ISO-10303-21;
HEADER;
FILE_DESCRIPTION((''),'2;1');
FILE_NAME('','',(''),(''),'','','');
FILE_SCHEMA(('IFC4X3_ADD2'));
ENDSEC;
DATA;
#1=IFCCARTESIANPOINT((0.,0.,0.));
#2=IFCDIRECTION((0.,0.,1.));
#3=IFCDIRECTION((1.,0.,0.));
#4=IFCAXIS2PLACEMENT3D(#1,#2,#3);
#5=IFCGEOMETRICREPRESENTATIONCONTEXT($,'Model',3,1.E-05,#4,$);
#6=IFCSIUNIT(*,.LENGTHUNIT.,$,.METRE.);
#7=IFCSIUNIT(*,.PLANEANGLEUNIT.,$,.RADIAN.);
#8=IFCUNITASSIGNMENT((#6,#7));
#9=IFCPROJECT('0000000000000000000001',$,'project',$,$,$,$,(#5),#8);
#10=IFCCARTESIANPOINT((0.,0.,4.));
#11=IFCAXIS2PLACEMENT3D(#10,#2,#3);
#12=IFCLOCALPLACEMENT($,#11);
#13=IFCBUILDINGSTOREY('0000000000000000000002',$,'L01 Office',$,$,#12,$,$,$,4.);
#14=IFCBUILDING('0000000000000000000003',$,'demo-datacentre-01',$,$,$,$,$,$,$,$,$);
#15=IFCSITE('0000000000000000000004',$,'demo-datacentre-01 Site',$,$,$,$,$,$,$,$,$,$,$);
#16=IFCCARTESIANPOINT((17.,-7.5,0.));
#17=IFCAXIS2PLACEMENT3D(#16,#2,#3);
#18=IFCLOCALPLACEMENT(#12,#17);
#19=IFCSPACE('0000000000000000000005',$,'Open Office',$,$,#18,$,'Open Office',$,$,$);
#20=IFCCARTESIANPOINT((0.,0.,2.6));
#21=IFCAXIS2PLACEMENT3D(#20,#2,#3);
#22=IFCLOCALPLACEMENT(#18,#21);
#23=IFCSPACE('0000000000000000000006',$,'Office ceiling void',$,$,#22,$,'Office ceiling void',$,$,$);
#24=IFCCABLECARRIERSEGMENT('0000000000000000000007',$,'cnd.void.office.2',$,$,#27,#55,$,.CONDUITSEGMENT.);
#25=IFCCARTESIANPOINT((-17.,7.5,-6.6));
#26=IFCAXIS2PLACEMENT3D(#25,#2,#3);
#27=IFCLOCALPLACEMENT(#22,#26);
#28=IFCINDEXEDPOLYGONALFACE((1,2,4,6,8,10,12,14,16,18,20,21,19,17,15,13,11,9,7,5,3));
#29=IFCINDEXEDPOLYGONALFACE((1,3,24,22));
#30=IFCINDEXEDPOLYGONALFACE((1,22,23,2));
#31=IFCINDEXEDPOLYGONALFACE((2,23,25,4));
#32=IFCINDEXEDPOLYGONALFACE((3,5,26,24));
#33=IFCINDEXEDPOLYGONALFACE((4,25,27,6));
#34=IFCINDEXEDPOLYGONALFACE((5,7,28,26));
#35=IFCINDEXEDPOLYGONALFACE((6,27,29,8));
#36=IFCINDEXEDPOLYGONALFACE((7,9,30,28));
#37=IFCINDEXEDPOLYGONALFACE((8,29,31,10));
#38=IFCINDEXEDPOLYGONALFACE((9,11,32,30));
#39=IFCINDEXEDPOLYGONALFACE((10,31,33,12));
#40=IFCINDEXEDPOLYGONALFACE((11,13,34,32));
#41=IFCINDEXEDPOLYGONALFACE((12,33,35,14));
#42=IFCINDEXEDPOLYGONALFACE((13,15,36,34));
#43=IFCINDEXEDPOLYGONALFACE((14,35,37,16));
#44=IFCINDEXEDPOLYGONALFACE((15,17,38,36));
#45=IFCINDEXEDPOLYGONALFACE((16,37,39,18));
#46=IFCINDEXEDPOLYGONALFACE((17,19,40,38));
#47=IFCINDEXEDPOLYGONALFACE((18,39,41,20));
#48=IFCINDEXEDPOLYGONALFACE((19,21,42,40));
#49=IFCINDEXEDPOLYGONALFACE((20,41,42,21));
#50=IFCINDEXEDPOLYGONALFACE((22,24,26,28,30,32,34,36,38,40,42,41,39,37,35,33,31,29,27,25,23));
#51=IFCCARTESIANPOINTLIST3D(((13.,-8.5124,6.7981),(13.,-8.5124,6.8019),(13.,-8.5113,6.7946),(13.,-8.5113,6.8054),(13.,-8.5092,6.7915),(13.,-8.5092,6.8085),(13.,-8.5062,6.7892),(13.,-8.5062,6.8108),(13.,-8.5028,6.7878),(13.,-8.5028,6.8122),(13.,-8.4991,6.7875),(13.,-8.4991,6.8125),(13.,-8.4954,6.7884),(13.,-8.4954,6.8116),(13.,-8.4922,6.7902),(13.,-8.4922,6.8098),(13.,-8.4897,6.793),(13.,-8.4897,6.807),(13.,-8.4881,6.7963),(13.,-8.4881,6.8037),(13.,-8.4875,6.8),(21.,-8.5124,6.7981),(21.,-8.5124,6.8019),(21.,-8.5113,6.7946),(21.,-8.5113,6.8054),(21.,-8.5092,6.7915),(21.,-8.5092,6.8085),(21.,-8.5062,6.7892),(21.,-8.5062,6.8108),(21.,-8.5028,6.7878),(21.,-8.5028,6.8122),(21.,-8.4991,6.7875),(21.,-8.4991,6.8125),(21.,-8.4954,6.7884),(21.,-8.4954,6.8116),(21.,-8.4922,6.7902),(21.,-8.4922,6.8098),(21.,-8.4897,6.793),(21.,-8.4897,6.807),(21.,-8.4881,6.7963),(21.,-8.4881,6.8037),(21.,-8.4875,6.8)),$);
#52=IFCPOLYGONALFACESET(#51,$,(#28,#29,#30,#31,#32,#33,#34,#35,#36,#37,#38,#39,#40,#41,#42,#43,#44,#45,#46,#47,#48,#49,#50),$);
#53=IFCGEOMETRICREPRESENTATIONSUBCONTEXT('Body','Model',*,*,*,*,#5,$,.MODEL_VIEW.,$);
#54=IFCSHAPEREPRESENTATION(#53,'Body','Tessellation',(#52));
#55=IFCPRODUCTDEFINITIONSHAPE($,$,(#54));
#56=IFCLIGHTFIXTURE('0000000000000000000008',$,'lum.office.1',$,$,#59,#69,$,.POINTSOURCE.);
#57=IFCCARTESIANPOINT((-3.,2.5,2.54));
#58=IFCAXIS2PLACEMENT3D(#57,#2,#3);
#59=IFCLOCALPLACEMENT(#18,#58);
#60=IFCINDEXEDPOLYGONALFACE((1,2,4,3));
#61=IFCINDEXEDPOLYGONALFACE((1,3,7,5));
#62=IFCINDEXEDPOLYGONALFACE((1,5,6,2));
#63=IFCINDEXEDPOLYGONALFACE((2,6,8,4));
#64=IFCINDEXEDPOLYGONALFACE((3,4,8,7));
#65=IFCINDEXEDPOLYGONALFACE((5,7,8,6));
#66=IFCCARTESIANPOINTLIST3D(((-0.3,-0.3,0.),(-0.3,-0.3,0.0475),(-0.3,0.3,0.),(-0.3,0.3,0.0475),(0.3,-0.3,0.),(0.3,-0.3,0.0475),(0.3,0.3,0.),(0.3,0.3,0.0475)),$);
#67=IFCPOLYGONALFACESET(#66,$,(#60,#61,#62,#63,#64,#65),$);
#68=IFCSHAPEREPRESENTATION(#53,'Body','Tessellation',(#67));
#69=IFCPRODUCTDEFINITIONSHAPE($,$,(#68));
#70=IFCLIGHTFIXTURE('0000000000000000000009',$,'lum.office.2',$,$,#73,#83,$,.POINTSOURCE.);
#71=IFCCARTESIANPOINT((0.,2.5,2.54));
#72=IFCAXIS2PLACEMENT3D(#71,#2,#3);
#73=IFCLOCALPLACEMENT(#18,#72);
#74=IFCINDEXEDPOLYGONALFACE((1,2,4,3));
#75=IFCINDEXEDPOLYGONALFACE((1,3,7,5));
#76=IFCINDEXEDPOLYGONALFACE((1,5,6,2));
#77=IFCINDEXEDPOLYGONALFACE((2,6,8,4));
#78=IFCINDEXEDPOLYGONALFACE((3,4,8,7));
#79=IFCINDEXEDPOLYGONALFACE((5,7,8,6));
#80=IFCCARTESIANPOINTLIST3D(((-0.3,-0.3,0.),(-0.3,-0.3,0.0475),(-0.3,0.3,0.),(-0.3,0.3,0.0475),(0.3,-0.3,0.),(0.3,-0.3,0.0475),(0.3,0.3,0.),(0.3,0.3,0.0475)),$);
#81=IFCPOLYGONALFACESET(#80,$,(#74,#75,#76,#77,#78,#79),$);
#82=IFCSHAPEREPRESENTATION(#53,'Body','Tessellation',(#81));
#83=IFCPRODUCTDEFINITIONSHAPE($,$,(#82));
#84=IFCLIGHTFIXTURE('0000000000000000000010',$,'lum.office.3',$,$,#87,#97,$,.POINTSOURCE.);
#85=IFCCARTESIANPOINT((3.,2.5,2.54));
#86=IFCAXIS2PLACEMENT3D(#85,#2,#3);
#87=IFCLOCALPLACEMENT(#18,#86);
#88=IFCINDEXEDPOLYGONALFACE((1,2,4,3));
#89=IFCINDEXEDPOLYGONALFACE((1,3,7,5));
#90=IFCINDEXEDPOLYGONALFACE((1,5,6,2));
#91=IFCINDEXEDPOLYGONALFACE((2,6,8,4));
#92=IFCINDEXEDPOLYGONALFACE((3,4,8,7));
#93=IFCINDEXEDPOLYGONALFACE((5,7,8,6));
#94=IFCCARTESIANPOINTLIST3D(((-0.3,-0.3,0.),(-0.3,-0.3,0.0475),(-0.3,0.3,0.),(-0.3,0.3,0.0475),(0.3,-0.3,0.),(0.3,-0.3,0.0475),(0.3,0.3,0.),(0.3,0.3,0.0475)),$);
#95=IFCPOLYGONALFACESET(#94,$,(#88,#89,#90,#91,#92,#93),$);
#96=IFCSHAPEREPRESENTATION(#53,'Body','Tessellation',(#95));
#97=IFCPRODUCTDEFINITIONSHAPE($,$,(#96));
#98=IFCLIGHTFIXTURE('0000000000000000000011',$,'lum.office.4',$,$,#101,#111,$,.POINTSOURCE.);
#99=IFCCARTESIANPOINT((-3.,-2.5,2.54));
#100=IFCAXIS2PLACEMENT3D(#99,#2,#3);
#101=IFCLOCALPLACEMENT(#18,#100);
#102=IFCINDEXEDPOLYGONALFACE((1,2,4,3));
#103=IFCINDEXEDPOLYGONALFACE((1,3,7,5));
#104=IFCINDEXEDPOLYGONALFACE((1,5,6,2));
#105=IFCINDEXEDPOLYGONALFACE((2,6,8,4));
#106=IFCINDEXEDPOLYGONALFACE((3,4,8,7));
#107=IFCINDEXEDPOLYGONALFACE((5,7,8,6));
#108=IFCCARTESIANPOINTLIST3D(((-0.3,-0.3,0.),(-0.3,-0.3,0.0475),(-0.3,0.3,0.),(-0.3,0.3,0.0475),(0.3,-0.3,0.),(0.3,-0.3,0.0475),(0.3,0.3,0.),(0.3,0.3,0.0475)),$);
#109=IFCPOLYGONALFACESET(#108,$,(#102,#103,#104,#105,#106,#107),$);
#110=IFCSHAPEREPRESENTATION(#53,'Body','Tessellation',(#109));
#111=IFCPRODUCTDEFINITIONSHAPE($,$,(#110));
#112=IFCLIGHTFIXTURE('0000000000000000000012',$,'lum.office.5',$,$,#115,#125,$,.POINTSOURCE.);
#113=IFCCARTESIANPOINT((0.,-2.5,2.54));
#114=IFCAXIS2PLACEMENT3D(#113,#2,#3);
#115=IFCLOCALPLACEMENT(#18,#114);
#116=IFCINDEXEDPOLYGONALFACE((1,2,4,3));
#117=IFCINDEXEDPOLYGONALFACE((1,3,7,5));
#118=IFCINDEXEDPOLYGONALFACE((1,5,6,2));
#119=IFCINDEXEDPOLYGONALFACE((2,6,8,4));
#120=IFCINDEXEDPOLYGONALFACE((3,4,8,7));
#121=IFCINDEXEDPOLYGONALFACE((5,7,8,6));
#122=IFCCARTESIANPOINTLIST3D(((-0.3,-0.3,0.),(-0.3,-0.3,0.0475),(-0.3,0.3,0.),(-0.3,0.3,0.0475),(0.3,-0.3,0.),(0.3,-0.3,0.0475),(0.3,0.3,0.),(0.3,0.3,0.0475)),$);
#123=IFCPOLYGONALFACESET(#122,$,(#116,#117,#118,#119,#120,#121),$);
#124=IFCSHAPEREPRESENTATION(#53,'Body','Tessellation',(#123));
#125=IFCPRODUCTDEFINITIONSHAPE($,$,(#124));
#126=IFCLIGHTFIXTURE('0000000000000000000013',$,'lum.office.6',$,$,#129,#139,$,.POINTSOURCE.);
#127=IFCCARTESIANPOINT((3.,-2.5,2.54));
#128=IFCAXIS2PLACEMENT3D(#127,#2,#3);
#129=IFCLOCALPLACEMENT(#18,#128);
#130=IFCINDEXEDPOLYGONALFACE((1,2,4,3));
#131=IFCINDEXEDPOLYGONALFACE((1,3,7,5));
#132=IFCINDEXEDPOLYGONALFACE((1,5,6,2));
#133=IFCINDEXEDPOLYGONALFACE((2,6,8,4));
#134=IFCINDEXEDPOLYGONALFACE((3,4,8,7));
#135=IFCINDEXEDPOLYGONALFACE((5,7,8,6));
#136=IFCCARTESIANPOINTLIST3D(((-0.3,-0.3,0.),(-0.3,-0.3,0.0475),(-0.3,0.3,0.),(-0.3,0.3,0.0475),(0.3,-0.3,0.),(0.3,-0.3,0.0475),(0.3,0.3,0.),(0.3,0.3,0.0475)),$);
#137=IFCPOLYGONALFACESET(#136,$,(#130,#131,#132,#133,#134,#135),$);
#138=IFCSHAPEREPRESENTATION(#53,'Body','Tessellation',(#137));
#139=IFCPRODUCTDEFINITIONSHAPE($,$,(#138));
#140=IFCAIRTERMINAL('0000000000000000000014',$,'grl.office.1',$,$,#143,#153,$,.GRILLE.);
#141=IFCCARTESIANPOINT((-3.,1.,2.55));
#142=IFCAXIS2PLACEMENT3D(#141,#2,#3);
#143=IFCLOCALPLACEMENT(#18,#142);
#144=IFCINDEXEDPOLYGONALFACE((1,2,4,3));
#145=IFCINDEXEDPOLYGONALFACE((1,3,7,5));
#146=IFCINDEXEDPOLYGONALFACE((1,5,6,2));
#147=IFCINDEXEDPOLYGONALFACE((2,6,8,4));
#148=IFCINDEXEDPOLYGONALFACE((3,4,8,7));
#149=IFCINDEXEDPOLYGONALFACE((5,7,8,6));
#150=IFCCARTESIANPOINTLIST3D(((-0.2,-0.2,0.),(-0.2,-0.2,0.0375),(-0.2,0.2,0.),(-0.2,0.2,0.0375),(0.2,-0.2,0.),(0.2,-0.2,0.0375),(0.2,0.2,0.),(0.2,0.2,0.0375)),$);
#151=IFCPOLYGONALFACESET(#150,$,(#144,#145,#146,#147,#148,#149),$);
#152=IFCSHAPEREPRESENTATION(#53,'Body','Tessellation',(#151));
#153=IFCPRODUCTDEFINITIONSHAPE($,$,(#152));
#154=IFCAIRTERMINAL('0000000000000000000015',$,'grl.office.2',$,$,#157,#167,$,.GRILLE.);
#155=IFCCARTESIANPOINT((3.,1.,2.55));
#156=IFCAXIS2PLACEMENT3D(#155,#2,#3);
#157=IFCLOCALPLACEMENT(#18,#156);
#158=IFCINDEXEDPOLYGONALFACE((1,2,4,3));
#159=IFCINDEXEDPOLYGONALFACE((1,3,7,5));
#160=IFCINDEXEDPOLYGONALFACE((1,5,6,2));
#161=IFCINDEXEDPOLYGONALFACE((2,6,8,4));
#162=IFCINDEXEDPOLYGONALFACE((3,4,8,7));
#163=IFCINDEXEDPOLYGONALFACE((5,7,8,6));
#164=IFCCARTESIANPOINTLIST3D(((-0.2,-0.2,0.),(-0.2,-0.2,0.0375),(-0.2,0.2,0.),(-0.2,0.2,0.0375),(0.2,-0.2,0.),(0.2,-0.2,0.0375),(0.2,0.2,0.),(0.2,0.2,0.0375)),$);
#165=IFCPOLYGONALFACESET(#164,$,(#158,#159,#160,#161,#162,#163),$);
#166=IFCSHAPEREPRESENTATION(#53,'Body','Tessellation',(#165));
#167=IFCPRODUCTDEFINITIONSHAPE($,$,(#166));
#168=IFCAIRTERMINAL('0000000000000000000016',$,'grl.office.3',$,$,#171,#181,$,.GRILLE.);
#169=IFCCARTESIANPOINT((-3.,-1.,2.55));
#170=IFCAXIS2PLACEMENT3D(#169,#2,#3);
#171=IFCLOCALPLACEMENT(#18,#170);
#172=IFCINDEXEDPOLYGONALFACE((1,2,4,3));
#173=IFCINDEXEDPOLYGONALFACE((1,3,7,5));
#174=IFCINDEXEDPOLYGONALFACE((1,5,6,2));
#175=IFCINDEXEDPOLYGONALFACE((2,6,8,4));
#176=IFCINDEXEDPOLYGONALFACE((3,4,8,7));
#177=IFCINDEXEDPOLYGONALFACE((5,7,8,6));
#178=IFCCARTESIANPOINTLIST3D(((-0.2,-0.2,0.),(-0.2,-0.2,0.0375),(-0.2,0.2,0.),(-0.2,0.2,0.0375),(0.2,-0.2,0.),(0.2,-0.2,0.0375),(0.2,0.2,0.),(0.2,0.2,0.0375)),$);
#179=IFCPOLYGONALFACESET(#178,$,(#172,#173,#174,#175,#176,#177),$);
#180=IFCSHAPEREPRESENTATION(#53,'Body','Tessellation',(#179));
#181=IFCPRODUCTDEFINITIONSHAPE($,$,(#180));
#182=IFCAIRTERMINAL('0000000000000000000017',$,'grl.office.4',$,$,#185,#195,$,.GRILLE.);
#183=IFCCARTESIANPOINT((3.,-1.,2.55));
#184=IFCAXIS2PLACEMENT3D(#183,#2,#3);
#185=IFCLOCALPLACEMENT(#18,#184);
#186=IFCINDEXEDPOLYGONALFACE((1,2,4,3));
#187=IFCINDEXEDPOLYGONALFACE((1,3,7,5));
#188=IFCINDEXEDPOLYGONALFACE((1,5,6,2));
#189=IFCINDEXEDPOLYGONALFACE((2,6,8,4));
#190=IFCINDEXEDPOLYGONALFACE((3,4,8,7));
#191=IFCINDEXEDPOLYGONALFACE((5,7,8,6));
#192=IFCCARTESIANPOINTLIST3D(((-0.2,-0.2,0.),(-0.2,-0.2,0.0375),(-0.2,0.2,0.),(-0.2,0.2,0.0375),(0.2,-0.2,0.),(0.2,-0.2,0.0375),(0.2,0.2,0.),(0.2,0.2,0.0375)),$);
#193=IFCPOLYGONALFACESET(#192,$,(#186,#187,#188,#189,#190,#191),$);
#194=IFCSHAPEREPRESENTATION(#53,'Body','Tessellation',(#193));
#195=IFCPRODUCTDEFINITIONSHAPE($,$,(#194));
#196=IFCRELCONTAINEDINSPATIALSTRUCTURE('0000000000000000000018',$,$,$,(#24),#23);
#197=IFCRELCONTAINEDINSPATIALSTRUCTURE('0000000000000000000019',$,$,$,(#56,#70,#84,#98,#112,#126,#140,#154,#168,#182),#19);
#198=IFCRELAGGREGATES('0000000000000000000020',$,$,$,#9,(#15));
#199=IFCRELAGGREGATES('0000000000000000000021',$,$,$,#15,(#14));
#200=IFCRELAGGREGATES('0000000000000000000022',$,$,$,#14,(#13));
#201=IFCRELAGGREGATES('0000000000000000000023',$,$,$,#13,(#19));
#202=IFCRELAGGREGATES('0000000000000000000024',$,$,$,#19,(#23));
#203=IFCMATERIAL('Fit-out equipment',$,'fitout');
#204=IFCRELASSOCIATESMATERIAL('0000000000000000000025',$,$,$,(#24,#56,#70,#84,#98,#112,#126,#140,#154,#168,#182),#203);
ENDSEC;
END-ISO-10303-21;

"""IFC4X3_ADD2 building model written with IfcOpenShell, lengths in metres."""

from ifc_helpers import new_model, si_unit, frame, origin_with_axes, place, context, subcontext, project, spatial, rectangle, circle, extrude, material, element, save


model = new_model("IFC4X3_ADD2")

# Units and contexts
model_context = context("Model", 3, precision=1e-05, world=origin_with_axes())
body_context = subcontext(model_context, "Body", "Model", "MODEL_VIEW")
ifc_project = project(units=[si_unit("LENGTHUNIT", "METRE"), si_unit("PLANEANGLEUNIT", "RADIAN")], contexts=[model_context])

# Site, building, storey, space
site = spatial("IfcSite", under=ifc_project, Name="demo-datacentre-01 Site")
building = spatial("IfcBuilding", under=site, Name="demo-datacentre-01")
storey_placement = place(None, frame((0.0, 0.0, 4.0), z_axis=(0.0, 0.0, 1.0), x_axis=(1.0, 0.0, 0.0)))
storey = spatial("IfcBuildingStorey", under=building, at=storey_placement, Name="L01 Office", Elevation=4.0)
space_1_placement = place(storey_placement, frame((17.0, -7.5, 0.0), z_axis=(0.0, 0.0, 1.0), x_axis=(1.0, 0.0, 0.0)))
space_1 = spatial("IfcSpace", under=storey, at=space_1_placement, Name="Open Office", LongName="Open Office")

# Shared definitions
ifc_material_1 = material(Name="Fit-out equipment", Category="fitout")

# Shared definitions
space_2_placement = place(space_1_placement, frame((0.0, 0.0, 2.6), z_axis=(0.0, 0.0, 1.0), x_axis=(1.0, 0.0, 0.0)))
space_2 = spatial("IfcSpace", under=space_1, at=space_2_placement, Name="Office ceiling void", LongName="Office ceiling void")

# Cable carrier segment
cable_carrier_segment_1_placement = place(space_2_placement, frame((-17.0, 7.5, -6.6), z_axis=(0.0, 0.0, 1.0), x_axis=(1.0, 0.0, 0.0)))
element("IfcCableCarrierSegment", 1, at=cable_carrier_segment_1_placement, inside=space_2, material=ifc_material_1, Name="cnd.void.office.2", PredefinedType="CONDUITSEGMENT", context=body_context, shape_type="SweptSolid", body=[
    extrude(circle(Radius=0.0125), frame((13.0, -8.5, 6.8), z_axis=(1.0, 0.0, 0.0), x_axis=(0.0, 1.0, 0.0)), (0.0, 0.0, 1.0), 8.0),
])

# Light fixtures
for number, where, z_axis, x_axis, name in (
    (2, (-3.0, 2.5, 2.54), (0.0, 0.0, 1.0), (1.0, 0.0, 0.0), "lum.office.1"),
    (3, (0.0, 2.5, 2.54), (0.0, 0.0, 1.0), (1.0, 0.0, 0.0), "lum.office.2"),
    (4, (3.0, 2.5, 2.54), (0.0, 0.0, 1.0), (1.0, 0.0, 0.0), "lum.office.3"),
    (5, (-3.0, -2.5, 2.54), (0.0, 0.0, 1.0), (1.0, 0.0, 0.0), "lum.office.4"),
    (6, (0.0, -2.5, 2.54), (0.0, 0.0, 1.0), (1.0, 0.0, 0.0), "lum.office.5"),
    (7, (3.0, -2.5, 2.54), (0.0, 0.0, 1.0), (1.0, 0.0, 0.0), "lum.office.6"),
):
    element("IfcLightFixture", number, at=place(space_1_placement, frame(where, z_axis=z_axis, x_axis=x_axis)), inside=space_1, material=ifc_material_1, Name=name, PredefinedType="POINTSOURCE", context=body_context, shape_type="SweptSolid", body=[
        extrude(rectangle(XDim=0.6, YDim=0.6), origin_with_axes(), (0.0, 0.0, 1.0), 0.0475),
    ])

# Air terminals
for number, where, z_axis, x_axis, name in (
    (8, (-3.0, 1.0, 2.55), (0.0, 0.0, 1.0), (1.0, 0.0, 0.0), "grl.office.1"),
    (9, (3.0, 1.0, 2.55), (0.0, 0.0, 1.0), (1.0, 0.0, 0.0), "grl.office.2"),
    (10, (-3.0, -1.0, 2.55), (0.0, 0.0, 1.0), (1.0, 0.0, 0.0), "grl.office.3"),
    (11, (3.0, -1.0, 2.55), (0.0, 0.0, 1.0), (1.0, 0.0, 0.0), "grl.office.4"),
):
    element("IfcAirTerminal", number, at=place(space_1_placement, frame(where, z_axis=z_axis, x_axis=x_axis)), inside=space_1, material=ifc_material_1, Name=name, PredefinedType="GRILLE", context=body_context, shape_type="SweptSolid", body=[
        extrude(rectangle(XDim=0.4, YDim=0.4), origin_with_axes(), (0.0, 0.0, 1.0), 0.0375),
    ])

save(model, "model.ifc")
